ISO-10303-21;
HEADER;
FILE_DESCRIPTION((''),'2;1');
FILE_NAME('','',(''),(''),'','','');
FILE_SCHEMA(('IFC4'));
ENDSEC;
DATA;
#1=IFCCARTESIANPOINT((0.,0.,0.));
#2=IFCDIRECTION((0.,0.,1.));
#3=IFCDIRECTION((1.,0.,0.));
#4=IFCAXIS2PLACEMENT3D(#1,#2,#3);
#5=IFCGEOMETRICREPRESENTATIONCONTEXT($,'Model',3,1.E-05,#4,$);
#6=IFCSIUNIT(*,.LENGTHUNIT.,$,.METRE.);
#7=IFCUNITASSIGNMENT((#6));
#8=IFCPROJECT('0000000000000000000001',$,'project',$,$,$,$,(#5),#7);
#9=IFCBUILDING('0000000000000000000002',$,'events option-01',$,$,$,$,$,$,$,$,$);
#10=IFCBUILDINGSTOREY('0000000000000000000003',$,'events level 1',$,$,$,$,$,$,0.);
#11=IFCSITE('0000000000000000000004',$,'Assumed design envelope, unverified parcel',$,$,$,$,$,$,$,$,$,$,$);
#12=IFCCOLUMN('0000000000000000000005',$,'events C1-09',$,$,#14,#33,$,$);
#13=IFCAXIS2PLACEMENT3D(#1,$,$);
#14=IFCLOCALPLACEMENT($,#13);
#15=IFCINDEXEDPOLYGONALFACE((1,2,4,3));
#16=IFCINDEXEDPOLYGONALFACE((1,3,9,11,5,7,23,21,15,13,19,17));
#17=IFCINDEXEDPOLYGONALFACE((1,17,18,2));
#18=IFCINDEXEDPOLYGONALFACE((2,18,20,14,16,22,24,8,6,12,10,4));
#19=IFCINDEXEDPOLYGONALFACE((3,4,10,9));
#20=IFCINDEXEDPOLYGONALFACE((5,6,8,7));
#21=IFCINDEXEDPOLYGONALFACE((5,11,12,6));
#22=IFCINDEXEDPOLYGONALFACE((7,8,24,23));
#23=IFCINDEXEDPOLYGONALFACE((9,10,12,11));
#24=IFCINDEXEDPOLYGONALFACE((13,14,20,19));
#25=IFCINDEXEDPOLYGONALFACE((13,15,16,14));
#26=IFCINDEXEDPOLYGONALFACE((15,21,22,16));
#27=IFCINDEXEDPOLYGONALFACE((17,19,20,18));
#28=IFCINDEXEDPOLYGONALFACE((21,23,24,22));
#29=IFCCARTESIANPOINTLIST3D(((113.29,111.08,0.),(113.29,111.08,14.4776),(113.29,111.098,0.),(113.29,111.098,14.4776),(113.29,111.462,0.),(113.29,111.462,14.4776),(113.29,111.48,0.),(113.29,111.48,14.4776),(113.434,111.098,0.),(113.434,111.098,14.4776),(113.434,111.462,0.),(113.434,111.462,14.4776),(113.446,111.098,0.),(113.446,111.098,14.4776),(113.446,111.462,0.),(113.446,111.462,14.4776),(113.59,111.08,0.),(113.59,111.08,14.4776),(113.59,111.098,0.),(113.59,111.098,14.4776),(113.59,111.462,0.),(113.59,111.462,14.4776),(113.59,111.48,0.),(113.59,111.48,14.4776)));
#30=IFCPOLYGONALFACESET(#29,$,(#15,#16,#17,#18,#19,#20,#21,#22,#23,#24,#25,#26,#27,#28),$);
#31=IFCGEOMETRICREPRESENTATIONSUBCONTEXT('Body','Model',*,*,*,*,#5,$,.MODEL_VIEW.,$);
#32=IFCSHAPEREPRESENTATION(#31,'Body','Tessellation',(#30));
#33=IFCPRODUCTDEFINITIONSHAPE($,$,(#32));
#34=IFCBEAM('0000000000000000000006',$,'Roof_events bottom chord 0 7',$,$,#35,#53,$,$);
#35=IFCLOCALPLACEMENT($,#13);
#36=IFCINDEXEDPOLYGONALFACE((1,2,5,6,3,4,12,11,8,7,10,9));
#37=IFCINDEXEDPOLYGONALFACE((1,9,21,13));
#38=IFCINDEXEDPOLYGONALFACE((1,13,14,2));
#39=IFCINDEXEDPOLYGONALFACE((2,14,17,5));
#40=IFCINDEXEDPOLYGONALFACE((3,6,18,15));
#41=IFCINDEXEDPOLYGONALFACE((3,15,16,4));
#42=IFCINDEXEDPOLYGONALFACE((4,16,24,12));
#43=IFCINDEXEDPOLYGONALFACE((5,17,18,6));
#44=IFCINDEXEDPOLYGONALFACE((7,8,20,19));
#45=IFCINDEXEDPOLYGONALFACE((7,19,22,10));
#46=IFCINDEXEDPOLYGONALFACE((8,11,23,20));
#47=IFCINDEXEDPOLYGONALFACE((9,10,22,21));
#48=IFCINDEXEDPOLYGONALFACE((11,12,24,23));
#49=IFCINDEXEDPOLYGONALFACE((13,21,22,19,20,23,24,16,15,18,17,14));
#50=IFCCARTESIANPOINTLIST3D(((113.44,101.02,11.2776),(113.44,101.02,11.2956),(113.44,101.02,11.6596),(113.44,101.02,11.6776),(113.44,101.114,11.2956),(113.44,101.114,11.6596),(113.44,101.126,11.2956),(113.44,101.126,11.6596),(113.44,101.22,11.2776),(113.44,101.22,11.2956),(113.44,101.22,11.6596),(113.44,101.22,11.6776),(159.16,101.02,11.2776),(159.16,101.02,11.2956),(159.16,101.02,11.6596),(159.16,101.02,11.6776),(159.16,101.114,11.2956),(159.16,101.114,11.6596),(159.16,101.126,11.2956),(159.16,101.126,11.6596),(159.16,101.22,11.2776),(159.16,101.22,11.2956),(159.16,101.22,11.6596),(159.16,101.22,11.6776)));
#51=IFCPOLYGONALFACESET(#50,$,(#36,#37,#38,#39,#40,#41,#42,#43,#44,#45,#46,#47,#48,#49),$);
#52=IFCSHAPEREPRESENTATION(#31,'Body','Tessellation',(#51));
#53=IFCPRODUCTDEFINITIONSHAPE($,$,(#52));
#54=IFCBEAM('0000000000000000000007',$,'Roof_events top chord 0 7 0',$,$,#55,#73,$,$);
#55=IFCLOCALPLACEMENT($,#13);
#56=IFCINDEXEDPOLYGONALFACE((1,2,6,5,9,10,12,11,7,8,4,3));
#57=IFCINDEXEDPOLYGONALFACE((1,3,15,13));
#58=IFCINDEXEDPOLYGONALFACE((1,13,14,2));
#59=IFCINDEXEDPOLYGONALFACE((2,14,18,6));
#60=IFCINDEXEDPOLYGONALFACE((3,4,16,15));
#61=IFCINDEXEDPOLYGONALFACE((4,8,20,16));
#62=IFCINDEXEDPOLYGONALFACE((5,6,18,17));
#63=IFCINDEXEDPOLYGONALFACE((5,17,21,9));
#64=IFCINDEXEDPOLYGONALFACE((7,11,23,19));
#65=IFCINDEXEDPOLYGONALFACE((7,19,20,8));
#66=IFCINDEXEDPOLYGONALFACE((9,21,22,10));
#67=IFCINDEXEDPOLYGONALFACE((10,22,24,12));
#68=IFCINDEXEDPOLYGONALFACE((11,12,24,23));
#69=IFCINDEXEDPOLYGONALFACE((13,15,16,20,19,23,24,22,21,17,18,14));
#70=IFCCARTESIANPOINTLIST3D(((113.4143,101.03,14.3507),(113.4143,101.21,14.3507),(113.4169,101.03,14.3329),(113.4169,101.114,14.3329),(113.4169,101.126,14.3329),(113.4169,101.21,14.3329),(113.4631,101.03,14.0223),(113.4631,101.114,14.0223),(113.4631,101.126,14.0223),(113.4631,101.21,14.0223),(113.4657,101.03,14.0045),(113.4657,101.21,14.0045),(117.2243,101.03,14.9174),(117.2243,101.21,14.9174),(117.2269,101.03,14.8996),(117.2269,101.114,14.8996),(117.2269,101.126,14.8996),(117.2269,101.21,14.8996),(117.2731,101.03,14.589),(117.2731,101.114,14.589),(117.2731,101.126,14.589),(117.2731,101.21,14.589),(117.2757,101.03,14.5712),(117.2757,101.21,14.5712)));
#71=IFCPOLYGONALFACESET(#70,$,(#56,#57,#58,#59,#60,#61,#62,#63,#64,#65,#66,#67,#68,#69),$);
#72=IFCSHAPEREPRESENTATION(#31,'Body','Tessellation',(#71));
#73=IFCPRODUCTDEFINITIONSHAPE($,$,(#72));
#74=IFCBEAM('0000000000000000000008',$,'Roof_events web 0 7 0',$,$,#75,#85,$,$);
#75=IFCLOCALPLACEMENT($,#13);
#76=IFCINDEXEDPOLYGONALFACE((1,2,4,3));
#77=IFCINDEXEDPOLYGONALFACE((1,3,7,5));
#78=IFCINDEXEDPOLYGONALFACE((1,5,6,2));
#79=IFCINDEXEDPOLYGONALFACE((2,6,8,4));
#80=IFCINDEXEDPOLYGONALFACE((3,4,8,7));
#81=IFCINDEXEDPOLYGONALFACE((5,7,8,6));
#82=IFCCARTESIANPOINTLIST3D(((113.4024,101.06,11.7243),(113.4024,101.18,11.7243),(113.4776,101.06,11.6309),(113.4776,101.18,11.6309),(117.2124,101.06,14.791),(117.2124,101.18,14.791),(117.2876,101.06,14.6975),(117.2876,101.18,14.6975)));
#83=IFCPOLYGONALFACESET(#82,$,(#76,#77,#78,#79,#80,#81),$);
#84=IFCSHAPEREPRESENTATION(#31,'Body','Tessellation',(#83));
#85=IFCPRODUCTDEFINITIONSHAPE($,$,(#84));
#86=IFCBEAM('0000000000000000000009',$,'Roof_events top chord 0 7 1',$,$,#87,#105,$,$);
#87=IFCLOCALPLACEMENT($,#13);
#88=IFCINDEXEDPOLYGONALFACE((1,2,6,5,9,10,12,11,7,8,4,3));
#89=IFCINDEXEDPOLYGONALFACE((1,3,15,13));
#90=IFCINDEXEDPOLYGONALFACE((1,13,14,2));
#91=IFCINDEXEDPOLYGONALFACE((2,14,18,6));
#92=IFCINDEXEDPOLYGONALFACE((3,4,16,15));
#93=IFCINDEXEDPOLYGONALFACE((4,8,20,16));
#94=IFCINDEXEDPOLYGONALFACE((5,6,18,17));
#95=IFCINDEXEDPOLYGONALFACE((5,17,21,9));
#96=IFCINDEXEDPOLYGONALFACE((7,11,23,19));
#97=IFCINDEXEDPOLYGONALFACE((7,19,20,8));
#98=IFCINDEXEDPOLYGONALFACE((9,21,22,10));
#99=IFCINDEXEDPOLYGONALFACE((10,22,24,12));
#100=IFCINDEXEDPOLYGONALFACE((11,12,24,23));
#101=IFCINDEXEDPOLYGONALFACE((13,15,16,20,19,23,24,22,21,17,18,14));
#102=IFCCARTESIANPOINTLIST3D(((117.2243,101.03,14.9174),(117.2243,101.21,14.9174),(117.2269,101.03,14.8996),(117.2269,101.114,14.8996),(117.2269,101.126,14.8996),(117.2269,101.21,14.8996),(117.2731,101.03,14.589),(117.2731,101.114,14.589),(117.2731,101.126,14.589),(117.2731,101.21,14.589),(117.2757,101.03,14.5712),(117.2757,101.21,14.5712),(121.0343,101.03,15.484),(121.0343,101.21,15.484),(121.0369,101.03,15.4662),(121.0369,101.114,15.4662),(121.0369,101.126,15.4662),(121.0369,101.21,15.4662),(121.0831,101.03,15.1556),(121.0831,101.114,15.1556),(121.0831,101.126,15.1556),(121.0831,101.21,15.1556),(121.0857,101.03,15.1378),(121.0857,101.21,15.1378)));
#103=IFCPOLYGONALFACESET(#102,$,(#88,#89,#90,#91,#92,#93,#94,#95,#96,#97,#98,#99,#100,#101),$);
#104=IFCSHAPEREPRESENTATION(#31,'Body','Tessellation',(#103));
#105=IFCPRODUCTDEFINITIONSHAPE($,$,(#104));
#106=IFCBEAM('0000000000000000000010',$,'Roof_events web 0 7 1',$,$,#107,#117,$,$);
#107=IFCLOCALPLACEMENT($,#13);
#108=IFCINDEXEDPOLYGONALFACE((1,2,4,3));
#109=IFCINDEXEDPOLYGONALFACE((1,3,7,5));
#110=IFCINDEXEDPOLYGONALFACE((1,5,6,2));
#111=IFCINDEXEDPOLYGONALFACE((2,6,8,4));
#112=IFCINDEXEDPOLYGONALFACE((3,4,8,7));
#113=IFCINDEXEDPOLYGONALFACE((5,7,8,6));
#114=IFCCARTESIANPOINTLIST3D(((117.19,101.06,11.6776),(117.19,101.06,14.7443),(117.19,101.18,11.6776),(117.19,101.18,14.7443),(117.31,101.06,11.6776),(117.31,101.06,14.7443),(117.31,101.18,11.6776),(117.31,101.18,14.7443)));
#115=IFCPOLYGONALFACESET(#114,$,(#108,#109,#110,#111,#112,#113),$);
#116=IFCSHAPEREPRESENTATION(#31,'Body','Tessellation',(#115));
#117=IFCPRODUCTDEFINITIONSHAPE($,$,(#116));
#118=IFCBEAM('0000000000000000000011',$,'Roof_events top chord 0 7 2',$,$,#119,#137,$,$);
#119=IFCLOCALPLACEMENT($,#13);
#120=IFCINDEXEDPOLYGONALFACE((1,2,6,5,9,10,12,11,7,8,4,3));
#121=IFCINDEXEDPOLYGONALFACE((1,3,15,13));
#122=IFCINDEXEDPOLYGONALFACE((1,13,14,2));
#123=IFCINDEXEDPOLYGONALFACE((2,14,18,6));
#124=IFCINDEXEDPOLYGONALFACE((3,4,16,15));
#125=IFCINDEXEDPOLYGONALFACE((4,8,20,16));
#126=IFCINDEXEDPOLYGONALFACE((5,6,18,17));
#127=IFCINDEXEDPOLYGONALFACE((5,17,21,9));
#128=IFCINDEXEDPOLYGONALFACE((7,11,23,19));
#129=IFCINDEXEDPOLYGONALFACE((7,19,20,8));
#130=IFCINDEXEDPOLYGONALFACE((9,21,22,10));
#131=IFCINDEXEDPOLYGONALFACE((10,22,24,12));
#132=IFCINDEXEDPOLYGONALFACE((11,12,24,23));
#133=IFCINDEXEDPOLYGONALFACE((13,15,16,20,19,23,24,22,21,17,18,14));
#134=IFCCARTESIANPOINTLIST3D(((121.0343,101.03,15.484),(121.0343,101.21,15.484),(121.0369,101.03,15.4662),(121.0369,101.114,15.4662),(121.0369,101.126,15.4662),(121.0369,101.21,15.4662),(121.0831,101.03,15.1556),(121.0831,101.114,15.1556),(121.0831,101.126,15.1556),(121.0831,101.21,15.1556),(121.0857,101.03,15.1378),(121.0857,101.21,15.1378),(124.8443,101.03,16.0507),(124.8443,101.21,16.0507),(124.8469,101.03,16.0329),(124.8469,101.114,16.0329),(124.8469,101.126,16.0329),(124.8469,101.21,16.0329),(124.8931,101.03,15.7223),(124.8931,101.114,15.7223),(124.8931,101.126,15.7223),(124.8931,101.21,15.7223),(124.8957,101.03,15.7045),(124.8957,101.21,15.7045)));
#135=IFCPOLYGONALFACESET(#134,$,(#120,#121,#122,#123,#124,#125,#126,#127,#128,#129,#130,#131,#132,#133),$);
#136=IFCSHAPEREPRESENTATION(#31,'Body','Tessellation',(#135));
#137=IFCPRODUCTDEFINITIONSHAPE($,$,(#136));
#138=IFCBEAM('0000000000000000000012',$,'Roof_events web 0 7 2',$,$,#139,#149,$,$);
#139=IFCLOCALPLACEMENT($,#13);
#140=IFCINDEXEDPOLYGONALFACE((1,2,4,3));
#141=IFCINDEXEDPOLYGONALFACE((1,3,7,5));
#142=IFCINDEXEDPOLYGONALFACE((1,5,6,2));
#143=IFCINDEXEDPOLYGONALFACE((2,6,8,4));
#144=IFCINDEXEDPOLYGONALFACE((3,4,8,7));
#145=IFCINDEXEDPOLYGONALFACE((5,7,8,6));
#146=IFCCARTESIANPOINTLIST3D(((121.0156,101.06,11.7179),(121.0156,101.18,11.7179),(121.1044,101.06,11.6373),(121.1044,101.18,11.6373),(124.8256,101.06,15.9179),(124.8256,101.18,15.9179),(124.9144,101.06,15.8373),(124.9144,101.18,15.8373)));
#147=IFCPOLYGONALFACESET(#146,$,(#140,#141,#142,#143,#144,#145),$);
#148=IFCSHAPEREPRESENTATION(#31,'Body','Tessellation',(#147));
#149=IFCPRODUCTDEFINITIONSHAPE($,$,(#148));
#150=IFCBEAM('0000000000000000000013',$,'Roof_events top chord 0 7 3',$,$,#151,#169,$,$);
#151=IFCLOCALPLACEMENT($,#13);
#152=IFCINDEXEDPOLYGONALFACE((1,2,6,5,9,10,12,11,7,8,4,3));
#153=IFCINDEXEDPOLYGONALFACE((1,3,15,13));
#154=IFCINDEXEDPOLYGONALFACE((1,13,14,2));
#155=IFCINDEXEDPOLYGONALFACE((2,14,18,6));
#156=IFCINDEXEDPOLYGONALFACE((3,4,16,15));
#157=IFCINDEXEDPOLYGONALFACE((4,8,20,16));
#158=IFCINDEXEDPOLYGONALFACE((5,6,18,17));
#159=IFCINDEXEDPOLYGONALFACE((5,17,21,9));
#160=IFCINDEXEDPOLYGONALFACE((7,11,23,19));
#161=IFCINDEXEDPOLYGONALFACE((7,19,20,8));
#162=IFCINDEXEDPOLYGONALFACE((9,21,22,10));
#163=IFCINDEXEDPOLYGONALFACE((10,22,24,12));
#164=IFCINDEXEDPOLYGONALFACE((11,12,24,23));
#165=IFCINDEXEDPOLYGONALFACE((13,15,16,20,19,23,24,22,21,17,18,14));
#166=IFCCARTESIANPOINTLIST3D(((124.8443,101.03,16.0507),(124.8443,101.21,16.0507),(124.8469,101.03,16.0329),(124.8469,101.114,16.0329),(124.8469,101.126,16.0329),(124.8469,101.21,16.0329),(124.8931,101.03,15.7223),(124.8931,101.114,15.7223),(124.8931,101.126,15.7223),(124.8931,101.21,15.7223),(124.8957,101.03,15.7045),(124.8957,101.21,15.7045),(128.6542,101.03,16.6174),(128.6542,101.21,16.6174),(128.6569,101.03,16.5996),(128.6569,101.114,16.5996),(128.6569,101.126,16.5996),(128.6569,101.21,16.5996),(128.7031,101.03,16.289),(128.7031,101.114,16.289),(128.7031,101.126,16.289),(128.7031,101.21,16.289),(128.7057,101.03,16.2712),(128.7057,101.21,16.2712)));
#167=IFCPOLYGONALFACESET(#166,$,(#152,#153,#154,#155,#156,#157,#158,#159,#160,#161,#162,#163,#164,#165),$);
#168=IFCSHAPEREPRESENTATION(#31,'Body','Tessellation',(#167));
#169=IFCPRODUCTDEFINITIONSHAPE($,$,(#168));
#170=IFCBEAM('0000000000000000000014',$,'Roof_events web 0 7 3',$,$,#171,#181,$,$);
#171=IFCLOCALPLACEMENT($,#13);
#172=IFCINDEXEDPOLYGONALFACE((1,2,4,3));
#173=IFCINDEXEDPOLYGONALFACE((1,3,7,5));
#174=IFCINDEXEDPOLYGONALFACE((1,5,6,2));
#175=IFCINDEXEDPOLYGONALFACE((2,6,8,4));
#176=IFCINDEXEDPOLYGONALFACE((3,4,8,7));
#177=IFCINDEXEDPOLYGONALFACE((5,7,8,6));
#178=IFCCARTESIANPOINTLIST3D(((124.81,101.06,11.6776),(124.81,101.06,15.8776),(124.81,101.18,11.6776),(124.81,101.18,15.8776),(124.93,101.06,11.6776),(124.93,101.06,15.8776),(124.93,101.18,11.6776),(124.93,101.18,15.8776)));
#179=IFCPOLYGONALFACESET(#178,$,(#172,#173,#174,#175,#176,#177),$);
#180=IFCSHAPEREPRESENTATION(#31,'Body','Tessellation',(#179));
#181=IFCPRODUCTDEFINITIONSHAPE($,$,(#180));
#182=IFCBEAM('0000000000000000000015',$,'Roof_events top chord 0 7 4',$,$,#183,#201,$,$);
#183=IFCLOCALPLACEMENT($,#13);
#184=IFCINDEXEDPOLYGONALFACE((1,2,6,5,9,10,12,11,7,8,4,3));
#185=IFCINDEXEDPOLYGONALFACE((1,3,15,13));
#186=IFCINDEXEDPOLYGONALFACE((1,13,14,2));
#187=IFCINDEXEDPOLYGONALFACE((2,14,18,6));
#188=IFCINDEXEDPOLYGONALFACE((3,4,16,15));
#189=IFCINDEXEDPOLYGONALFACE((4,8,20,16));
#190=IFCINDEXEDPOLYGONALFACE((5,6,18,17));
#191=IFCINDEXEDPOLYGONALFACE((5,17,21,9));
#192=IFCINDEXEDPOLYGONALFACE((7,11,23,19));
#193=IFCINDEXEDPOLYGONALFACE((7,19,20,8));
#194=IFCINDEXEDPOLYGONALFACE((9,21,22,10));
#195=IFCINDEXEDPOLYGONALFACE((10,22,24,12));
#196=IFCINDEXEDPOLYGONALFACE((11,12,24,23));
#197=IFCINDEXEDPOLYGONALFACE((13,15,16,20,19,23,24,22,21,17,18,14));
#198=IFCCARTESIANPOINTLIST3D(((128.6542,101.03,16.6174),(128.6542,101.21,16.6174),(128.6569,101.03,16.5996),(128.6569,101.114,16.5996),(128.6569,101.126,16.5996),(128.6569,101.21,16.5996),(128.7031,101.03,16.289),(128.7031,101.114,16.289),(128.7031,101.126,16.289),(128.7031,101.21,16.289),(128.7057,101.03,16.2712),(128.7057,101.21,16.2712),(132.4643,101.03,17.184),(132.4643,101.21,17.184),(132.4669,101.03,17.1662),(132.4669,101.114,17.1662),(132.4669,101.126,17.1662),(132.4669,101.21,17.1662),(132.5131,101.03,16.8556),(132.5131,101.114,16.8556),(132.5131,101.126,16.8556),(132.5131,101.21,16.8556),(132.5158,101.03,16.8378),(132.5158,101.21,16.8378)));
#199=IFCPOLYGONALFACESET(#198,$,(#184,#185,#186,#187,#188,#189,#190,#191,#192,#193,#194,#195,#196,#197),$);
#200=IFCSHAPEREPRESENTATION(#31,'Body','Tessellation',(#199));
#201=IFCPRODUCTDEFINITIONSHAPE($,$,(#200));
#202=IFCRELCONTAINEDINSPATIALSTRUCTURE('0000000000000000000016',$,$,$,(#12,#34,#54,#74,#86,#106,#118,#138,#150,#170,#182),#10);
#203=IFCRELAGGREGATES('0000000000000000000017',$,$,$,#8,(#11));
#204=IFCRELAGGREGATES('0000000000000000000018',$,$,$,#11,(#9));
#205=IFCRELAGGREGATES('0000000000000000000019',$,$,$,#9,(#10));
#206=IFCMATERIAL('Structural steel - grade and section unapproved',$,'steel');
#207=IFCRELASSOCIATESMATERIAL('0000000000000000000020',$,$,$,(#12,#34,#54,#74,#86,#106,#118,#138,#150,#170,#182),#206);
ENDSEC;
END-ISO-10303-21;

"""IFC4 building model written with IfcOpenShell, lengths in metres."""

from ifc_helpers import new_model, si_unit, frame, origin_with_axes, place, context, subcontext, project, spatial, rectangle, i_section, extrude, material, element, save


model = new_model("IFC4")

# Units and contexts
model_context = context("Model", 3, precision=1e-05, world=origin_with_axes())
body_context = subcontext(model_context, "Body", "Model", "MODEL_VIEW")
ifc_project = project(units=[si_unit("LENGTHUNIT", "METRE")], contexts=[model_context])

# Site, building, storey
site = spatial("IfcSite", under=ifc_project, Name="Assumed design envelope, unverified parcel")
building = spatial("IfcBuilding", under=site, Name="events option-01")
storey = spatial("IfcBuildingStorey", under=building, Name="events level 1", Elevation=0.0)

# Column
ifc_material_1 = material(Name="Structural steel - grade and section unapproved", Category="steel")
column_placement = place(None, frame((113.44, 111.28, 0.0), z_axis=(0.0, 0.0, 1.0), x_axis=(-1.0, 0.0, 0.0)))
element("IfcColumn", 1, at=column_placement, inside=storey, material=ifc_material_1, Name="events C1-09", context=body_context, shape_type="SweptSolid", body=[
    extrude(i_section(OverallWidth=0.3, OverallDepth=0.4, WebThickness=0.012, FlangeThickness=0.018, FilletRadius=0.0), origin_with_axes(), (0.0, 0.0, 1.0), 14.4776),
])

# Beams
beam_1_placement = place(None, frame((113.44, 101.12, 11.4776), z_axis=(1.0, 0.0, 0.0), x_axis=(0.0, 1.0, 0.0)))
element("IfcBeam", 2, at=beam_1_placement, inside=storey, material=ifc_material_1, Name="Roof_events bottom chord 0 7", context=body_context, shape_type="SweptSolid", body=[
    extrude(i_section(OverallWidth=0.2, OverallDepth=0.4, WebThickness=0.012, FlangeThickness=0.018, FilletRadius=0.0), origin_with_axes(), (0.0, 0.0, 1.0), 45.72),
])
beam_2_placement = place(None, frame((113.44, 101.12, 14.1776), z_axis=(0.98912, 0.0, 0.147113), x_axis=(0.0, 1.0, 0.0)))
element("IfcBeam", 3, at=beam_2_placement, inside=storey, material=ifc_material_1, Name="Roof_events top chord 0 7 0", context=body_context, shape_type="SweptSolid", body=[
    extrude(i_section(OverallWidth=0.18, OverallDepth=0.35, WebThickness=0.012, FlangeThickness=0.018, FilletRadius=0.0), origin_with_axes(), (0.0, 0.0, 1.0), 3.8519),
])
beam_3_placement = place(None, frame((113.44, 101.12, 11.6776), z_axis=(0.779003, 0.0, 0.62702), x_axis=(0.0, 1.0, 0.0)))
element("IfcBeam", 4, at=beam_3_placement, inside=storey, material=ifc_material_1, Name="Roof_events web 0 7 0", context=body_context, shape_type="SweptSolid", body=[
    extrude(rectangle(XDim=0.12, YDim=0.12), origin_with_axes(), (0.0, 0.0, 1.0), 4.8909),
])
beam_4_placement = place(None, frame((117.25, 101.12, 14.7443), z_axis=(0.98912, 0.0, 0.147113), x_axis=(0.0, 1.0, 0.0)))
element("IfcBeam", 5, at=beam_4_placement, inside=storey, material=ifc_material_1, Name="Roof_events top chord 0 7 1", context=body_context, shape_type="SweptSolid", body=[
    extrude(i_section(OverallWidth=0.18, OverallDepth=0.35, WebThickness=0.012, FlangeThickness=0.018, FilletRadius=0.0), origin_with_axes(), (0.0, 0.0, 1.0), 3.8519),
])
beam_5_placement = place(None, frame((117.25, 101.12, 11.6776), z_axis=(0.0, 0.0, 1.0), x_axis=(-1.0, 0.0, 0.0)))
element("IfcBeam", 6, at=beam_5_placement, inside=storey, material=ifc_material_1, Name="Roof_events web 0 7 1", context=body_context, shape_type="SweptSolid", body=[
    extrude(rectangle(XDim=0.12, YDim=0.12), origin_with_axes(), (0.0, 0.0, 1.0), 3.0667),
])
beam_6_placement = place(None, frame((121.06, 101.12, 15.3109), z_axis=(0.98912, 0.0, 0.147113), x_axis=(0.0, 1.0, 0.0)))
element("IfcBeam", 7, at=beam_6_placement, inside=storey, material=ifc_material_1, Name="Roof_events top chord 0 7 2", context=body_context, shape_type="SweptSolid", body=[
    extrude(i_section(OverallWidth=0.18, OverallDepth=0.35, WebThickness=0.012, FlangeThickness=0.018, FilletRadius=0.0), origin_with_axes(), (0.0, 0.0, 1.0), 3.8519),
])
beam_7_placement = place(None, frame((121.06, 101.12, 11.6776), z_axis=(0.671883, 0.0, 0.740657), x_axis=(0.0, 1.0, 0.0)))
element("IfcBeam", 8, at=beam_7_placement, inside=storey, material=ifc_material_1, Name="Roof_events web 0 7 2", context=body_context, shape_type="SweptSolid", body=[
    extrude(rectangle(XDim=0.12, YDim=0.12), origin_with_axes(), (0.0, 0.0, 1.0), 5.6706),
])
beam_8_placement = place(None, frame((124.87, 101.12, 15.8776), z_axis=(0.98912, 0.0, 0.147114), x_axis=(0.0, 1.0, 0.0)))
element("IfcBeam", 9, at=beam_8_placement, inside=storey, material=ifc_material_1, Name="Roof_events top chord 0 7 3", context=body_context, shape_type="SweptSolid", body=[
    extrude(i_section(OverallWidth=0.18, OverallDepth=0.35, WebThickness=0.012, FlangeThickness=0.018, FilletRadius=0.0), origin_with_axes(), (0.0, 0.0, 1.0), 3.8519),
])
beam_9_placement = place(None, frame((124.87, 101.12, 11.6776), z_axis=(0.0, 0.0, 1.0), x_axis=(-1.0, 0.0, 0.0)))
element("IfcBeam", 10, at=beam_9_placement, inside=storey, material=ifc_material_1, Name="Roof_events web 0 7 3", context=body_context, shape_type="SweptSolid", body=[
    extrude(rectangle(XDim=0.12, YDim=0.12), origin_with_axes(), (0.0, 0.0, 1.0), 4.2),
])
beam_10_placement = place(None, frame((128.68, 101.12, 16.4443), z_axis=(0.98912, 0.0, 0.147112), x_axis=(0.0, 1.0, 0.0)))
element("IfcBeam", 11, at=beam_10_placement, inside=storey, material=ifc_material_1, Name="Roof_events top chord 0 7 4", context=body_context, shape_type="SweptSolid", body=[
    extrude(i_section(OverallWidth=0.18, OverallDepth=0.35, WebThickness=0.012, FlangeThickness=0.018, FilletRadius=0.0), origin_with_axes(), (0.0, 0.0, 1.0), 3.8519),
])

save(model, "model.ifc")
